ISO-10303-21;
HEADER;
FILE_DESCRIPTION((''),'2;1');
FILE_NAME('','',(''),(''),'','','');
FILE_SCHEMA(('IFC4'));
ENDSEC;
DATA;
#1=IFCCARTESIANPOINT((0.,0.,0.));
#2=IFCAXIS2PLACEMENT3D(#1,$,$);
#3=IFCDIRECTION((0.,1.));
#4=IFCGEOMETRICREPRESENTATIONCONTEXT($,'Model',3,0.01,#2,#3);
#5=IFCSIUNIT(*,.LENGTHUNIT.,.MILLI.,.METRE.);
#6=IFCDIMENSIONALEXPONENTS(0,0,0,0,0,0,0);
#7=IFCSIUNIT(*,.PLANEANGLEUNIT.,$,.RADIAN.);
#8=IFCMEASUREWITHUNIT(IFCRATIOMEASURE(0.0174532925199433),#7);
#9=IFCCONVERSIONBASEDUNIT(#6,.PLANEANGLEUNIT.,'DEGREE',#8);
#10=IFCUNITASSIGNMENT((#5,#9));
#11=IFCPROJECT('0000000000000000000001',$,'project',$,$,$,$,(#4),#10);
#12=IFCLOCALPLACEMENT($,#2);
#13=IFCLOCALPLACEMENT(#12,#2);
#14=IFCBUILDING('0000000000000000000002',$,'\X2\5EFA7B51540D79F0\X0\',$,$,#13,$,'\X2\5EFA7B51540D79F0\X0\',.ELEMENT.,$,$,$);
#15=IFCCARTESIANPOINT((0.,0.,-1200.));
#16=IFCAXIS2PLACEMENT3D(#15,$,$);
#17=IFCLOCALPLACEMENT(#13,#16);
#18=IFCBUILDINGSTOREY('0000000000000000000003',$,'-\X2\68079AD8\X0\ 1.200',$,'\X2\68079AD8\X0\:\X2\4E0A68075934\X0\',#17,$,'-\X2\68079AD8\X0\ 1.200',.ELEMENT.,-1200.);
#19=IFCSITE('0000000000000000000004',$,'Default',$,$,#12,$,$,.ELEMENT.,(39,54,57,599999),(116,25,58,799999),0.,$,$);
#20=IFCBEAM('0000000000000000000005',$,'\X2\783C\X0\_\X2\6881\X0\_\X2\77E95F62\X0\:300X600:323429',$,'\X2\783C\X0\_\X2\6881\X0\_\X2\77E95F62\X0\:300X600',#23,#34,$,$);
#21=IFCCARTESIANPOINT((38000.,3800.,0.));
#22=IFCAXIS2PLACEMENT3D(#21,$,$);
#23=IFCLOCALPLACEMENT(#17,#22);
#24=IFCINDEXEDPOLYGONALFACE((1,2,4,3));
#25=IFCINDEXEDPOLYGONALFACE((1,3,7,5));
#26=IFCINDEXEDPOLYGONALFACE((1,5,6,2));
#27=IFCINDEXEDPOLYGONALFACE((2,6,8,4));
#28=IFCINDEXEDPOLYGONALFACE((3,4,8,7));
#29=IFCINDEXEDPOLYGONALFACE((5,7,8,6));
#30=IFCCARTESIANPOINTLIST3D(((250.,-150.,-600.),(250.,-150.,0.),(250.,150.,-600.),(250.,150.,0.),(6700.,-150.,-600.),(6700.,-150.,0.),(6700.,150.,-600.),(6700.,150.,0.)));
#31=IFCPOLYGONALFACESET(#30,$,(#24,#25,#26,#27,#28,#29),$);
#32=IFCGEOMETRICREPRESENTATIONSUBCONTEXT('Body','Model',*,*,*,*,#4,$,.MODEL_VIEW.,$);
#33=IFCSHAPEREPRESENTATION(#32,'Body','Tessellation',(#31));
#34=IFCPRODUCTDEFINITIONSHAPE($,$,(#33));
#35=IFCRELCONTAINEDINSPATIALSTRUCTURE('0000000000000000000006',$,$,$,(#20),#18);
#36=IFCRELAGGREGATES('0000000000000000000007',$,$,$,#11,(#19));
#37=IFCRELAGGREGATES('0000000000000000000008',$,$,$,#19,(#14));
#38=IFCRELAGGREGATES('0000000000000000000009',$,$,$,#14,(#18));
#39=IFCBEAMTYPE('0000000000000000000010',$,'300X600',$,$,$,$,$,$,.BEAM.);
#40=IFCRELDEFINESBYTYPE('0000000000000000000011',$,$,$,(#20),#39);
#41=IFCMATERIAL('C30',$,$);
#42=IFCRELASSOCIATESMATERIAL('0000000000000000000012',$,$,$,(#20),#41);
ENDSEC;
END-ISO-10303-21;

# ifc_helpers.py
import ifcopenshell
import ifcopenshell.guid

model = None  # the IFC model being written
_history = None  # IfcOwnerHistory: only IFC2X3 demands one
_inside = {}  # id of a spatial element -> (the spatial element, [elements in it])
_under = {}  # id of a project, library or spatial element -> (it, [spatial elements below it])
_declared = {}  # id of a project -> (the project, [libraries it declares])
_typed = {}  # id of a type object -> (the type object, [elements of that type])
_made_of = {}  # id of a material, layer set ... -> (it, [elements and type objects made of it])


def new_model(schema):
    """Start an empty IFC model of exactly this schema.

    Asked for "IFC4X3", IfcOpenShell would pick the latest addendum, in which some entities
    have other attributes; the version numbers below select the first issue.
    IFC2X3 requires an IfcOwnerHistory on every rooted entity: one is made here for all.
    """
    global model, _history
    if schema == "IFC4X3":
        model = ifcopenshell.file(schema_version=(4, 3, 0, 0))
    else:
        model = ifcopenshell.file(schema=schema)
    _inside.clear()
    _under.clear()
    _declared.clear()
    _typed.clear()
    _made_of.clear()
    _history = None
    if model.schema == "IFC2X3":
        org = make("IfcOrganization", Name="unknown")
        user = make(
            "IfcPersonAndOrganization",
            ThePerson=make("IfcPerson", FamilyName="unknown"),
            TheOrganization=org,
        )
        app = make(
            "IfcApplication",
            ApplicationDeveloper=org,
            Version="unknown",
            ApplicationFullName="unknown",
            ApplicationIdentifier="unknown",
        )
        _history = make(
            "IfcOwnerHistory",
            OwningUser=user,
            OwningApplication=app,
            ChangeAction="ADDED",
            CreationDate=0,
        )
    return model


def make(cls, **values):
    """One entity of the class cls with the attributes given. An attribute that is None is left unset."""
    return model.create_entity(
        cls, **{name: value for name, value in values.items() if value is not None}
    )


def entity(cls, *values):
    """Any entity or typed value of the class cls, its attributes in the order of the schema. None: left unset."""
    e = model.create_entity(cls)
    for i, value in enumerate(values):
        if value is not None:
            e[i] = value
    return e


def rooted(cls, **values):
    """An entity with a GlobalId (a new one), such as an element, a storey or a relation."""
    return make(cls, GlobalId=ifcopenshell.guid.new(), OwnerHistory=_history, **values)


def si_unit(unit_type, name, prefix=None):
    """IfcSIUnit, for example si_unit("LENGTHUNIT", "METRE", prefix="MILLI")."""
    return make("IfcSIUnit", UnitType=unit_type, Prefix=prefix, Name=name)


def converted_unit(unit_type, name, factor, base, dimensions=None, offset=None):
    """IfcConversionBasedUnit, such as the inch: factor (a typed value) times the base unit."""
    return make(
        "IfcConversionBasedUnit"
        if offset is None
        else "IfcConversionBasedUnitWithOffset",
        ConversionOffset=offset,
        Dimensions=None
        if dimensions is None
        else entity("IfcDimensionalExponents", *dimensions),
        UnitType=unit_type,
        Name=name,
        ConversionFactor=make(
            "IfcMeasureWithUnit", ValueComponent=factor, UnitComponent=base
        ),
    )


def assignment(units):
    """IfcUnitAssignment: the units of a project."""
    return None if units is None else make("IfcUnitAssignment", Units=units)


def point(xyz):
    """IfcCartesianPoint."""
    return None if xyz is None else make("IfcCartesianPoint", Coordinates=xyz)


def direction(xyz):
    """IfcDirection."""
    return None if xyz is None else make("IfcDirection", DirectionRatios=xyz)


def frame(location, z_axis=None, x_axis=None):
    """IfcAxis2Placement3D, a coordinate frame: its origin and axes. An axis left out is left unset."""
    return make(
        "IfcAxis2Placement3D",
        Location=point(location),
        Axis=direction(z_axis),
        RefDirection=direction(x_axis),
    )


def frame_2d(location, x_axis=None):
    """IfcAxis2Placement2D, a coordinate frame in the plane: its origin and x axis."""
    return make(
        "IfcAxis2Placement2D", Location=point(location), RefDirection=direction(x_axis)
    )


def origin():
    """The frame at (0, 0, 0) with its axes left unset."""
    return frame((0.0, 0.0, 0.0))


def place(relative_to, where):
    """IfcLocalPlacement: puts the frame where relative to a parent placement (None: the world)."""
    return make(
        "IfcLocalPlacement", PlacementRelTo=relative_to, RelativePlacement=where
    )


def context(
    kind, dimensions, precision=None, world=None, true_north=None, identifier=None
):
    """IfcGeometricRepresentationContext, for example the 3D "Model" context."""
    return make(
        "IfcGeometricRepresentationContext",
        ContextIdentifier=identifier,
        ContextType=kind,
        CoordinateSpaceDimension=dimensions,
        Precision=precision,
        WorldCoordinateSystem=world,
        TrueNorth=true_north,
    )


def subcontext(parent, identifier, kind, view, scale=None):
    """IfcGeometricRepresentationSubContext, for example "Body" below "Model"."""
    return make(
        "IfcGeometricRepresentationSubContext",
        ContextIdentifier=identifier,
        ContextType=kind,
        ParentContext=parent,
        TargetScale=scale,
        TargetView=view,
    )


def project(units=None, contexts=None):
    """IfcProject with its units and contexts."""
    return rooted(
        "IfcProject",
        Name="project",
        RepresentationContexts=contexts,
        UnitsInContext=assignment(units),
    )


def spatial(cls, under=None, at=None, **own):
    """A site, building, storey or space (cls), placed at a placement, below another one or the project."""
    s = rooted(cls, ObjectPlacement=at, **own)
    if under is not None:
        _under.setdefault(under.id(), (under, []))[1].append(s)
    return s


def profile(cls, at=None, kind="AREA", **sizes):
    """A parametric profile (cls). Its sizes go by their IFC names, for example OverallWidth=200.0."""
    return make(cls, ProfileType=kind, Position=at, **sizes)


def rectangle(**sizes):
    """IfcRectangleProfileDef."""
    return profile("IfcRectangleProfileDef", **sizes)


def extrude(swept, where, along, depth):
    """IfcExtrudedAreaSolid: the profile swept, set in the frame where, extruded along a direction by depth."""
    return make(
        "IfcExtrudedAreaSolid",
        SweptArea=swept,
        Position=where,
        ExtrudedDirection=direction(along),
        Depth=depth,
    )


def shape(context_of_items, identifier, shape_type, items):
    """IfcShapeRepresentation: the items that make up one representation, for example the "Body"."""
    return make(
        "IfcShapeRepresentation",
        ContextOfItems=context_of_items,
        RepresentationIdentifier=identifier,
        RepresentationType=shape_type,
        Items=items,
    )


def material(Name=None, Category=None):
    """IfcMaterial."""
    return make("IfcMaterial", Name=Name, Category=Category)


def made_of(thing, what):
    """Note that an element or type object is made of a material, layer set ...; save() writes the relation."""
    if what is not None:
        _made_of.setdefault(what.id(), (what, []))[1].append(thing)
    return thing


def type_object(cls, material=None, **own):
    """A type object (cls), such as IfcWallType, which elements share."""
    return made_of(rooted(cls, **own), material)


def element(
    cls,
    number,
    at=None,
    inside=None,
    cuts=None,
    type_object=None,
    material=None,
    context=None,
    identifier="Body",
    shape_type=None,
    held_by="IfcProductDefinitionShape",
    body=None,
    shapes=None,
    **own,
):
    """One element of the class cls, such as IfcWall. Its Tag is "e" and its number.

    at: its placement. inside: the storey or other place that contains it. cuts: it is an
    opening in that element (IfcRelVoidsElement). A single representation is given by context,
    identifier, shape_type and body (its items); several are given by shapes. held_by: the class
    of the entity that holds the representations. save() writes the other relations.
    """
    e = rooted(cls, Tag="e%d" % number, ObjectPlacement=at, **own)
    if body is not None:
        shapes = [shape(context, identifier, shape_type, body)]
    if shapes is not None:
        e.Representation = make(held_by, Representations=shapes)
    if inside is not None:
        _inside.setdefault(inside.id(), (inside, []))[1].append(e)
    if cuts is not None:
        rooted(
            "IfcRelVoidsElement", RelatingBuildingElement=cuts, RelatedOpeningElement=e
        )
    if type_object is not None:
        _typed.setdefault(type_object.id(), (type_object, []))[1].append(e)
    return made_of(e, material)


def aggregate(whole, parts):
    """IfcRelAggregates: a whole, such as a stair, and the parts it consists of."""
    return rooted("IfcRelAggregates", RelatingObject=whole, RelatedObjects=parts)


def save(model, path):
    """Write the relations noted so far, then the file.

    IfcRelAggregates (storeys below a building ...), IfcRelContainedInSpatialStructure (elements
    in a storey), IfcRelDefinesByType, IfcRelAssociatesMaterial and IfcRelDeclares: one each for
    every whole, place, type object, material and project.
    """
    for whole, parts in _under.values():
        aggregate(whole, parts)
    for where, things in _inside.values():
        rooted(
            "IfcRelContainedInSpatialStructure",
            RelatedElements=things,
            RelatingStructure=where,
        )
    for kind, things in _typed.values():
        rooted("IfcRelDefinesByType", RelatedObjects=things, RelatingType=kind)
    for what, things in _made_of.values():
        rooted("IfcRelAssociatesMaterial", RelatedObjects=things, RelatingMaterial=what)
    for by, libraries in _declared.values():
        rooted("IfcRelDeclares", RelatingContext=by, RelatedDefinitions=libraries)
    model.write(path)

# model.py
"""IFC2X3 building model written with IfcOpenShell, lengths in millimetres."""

from ifc_helpers import new_model, entity, si_unit, converted_unit, direction, frame, frame_2d, origin, place, context, subcontext, project, spatial, rectangle, extrude, material, type_object, element, save


model = new_model("IFC2X3")

# Units and contexts
model_context = context("Model", 3, precision=0.01, world=origin(), true_north=direction((0.0, 1.0)))
body_context = subcontext(model_context, "Body", "Model", "MODEL_VIEW")
ifc_project = project(units=[si_unit("LENGTHUNIT", "METRE", prefix="MILLI"), converted_unit("PLANEANGLEUNIT", "DEGREE", entity("IfcRatioMeasure", 0.0174532925199433), si_unit("PLANEANGLEUNIT", "RADIAN"), dimensions=[0, 0, 0, 0, 0, 0, 0])], contexts=[model_context])

# Site, building, storey
site_placement = place(None, origin())
site = spatial("IfcSite", under=ifc_project, at=site_placement, Name="Default", CompositionType="ELEMENT", RefLatitude=(39, 54, 57, 599999), RefLongitude=(116, 25, 58, 799999), RefElevation=0.0)
building_placement = place(site_placement, origin())
building = spatial("IfcBuilding", under=site, at=building_placement, Name="建筑名称", LongName="建筑名称", CompositionType="ELEMENT")
storey_placement = place(building_placement, frame((0.0, 0.0, -1200.0)))
storey = spatial("IfcBuildingStorey", under=building, at=storey_placement, Name="-标高 1.200", ObjectType="标高:上标头", LongName="-标高 1.200", CompositionType="ELEMENT", Elevation=-1200.0)

# Beam
ifc_material_1 = material(Name="C30")
beam_type_1 = type_object("IfcBeamType", Name="300X600", PredefinedType="BEAM")
beam_1_placement = place(storey_placement, frame((38000.0, 3800.0, 0.0)))
element("IfcBeam", 1, at=beam_1_placement, inside=storey, type_object=beam_type_1, material=ifc_material_1, Name="砼_梁_矩形:300X600:323429", ObjectType="砼_梁_矩形:300X600", context=body_context, shape_type="SweptSolid", body=[
    extrude(rectangle(XDim=600.0, YDim=300.0, at=frame_2d((0.0, 0.0), x_axis=(1.0, 0.0))), frame((250.0, 0.0, -300.0), z_axis=(1.0, 0.0, 0.0), x_axis=(0.0, 0.0, -1.0)), (0.0, 0.0, 1.0), 6450.0),
])

save(model, "model.ifc")
